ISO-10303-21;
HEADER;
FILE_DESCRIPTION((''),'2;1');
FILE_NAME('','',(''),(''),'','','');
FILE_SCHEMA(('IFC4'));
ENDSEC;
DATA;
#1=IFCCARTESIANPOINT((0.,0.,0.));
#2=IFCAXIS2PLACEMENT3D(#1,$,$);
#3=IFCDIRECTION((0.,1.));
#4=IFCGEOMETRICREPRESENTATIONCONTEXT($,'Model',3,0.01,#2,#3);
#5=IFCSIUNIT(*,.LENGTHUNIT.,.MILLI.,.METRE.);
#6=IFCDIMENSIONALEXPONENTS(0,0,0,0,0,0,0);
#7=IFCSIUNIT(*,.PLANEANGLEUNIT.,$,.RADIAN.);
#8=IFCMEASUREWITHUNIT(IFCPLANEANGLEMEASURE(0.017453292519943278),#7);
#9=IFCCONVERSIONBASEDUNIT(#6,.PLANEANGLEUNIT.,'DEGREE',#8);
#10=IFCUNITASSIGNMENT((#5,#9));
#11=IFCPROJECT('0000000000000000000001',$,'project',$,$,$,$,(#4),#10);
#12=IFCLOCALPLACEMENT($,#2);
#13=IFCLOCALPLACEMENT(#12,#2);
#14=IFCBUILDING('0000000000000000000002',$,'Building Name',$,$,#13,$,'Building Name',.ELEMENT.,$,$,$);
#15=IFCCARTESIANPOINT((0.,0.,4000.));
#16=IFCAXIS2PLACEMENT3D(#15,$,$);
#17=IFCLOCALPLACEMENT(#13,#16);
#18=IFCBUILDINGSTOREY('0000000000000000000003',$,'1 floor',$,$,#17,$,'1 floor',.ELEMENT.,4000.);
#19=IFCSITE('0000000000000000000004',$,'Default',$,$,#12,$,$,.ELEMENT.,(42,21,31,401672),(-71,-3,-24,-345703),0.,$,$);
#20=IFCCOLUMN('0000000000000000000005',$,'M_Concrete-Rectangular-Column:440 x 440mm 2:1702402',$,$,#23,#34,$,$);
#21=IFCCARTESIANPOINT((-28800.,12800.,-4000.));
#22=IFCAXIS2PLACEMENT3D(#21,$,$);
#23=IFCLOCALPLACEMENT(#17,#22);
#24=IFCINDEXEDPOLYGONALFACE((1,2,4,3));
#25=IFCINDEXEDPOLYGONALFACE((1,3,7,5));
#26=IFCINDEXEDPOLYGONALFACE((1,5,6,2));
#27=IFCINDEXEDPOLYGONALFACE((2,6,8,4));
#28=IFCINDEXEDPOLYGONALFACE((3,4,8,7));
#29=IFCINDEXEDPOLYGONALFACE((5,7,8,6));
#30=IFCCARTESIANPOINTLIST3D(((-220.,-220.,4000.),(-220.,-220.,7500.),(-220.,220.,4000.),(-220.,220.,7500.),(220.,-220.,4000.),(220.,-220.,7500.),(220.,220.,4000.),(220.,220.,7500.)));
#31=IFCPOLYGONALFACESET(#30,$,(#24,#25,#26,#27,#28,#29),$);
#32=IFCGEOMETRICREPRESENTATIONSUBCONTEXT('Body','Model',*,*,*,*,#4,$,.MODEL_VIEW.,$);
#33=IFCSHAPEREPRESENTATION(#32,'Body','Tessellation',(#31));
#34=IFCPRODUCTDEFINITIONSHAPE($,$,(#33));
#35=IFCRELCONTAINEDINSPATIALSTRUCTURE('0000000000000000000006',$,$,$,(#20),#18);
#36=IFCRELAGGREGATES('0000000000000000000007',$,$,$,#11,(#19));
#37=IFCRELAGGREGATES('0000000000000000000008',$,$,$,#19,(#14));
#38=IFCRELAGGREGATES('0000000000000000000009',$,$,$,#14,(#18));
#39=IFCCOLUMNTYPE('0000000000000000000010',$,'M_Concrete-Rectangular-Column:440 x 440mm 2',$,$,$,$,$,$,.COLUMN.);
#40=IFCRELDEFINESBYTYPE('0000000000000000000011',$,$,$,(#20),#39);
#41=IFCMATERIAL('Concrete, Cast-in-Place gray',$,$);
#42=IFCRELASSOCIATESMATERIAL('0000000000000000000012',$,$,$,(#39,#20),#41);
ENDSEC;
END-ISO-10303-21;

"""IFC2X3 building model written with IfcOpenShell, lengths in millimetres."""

from ifc_helpers import new_model, entity, si_unit, converted_unit, direction, frame, origin, origin_2d_with_axis, place, context, subcontext, project, spatial, rectangle, extrude, source, transform, mapped, material, type_object, type_shapes, element, save


model = new_model("IFC2X3")

# Units and contexts
model_context = context("Model", 3, precision=0.01, world=origin(), true_north=direction((0.0, 1.0)))
body_context = subcontext(model_context, "Body", "Model", "MODEL_VIEW")
ifc_project = project(units=[si_unit("LENGTHUNIT", "METRE", prefix="MILLI"), converted_unit("PLANEANGLEUNIT", "DEGREE", entity("IfcPlaneAngleMeasure", 0.017453292519943278), si_unit("PLANEANGLEUNIT", "RADIAN"), dimensions=[0, 0, 0, 0, 0, 0, 0])], contexts=[model_context])

# Site, building, storey
site_placement = place(None, origin())
site = spatial("IfcSite", under=ifc_project, at=site_placement, Name="Default", CompositionType="ELEMENT", RefLatitude=(42, 21, 31, 401672), RefLongitude=(-71, -3, -24, -345703), RefElevation=0.0)
building_placement = place(site_placement, origin())
building = spatial("IfcBuilding", under=site, at=building_placement, Name="Building Name", LongName="Building Name", CompositionType="ELEMENT")
storey_placement = place(building_placement, frame((0.0, 0.0, 4000.0)))
storey = spatial("IfcBuildingStorey", under=building, at=storey_placement, Name="1 floor", LongName="1 floor", CompositionType="ELEMENT", Elevation=4000.0)

# Column
ifc_material_1 = material(Name="Concrete, Cast-in-Place gray")
column_type = type_object("IfcColumnType", Name="M_Concrete-Rectangular-Column:440 x 440mm 2", PredefinedType="COLUMN", material=ifc_material_1)
shared_shape_1 = source(origin(), body_context, "Body", "SweptSolid", [
    extrude(rectangle(XDim=440.0, YDim=440.0, at=origin_2d_with_axis()), frame((0.0, 0.0, 4000.0), z_axis=(0.0, 0.0, 1.0), x_axis=(-1.0, 0.0, 0.0)), (0.0, 0.0, 1.0), 3500.0),
])
type_shapes(column_type, [shared_shape_1])
column_placement = place(storey_placement, frame((-28800.0, 12800.0, -4000.0)))
element("IfcColumn", 1, at=column_placement, inside=storey, type_object=column_type, material=ifc_material_1, Name="M_Concrete-Rectangular-Column:440 x 440mm 2:1702402", context=body_context, shape_type="MappedRepresentation", body=[
    mapped(shared_shape_1, transform((0.0, 0.0, 0.0), scale=1.0)),
])

save(model, "model.ifc")
